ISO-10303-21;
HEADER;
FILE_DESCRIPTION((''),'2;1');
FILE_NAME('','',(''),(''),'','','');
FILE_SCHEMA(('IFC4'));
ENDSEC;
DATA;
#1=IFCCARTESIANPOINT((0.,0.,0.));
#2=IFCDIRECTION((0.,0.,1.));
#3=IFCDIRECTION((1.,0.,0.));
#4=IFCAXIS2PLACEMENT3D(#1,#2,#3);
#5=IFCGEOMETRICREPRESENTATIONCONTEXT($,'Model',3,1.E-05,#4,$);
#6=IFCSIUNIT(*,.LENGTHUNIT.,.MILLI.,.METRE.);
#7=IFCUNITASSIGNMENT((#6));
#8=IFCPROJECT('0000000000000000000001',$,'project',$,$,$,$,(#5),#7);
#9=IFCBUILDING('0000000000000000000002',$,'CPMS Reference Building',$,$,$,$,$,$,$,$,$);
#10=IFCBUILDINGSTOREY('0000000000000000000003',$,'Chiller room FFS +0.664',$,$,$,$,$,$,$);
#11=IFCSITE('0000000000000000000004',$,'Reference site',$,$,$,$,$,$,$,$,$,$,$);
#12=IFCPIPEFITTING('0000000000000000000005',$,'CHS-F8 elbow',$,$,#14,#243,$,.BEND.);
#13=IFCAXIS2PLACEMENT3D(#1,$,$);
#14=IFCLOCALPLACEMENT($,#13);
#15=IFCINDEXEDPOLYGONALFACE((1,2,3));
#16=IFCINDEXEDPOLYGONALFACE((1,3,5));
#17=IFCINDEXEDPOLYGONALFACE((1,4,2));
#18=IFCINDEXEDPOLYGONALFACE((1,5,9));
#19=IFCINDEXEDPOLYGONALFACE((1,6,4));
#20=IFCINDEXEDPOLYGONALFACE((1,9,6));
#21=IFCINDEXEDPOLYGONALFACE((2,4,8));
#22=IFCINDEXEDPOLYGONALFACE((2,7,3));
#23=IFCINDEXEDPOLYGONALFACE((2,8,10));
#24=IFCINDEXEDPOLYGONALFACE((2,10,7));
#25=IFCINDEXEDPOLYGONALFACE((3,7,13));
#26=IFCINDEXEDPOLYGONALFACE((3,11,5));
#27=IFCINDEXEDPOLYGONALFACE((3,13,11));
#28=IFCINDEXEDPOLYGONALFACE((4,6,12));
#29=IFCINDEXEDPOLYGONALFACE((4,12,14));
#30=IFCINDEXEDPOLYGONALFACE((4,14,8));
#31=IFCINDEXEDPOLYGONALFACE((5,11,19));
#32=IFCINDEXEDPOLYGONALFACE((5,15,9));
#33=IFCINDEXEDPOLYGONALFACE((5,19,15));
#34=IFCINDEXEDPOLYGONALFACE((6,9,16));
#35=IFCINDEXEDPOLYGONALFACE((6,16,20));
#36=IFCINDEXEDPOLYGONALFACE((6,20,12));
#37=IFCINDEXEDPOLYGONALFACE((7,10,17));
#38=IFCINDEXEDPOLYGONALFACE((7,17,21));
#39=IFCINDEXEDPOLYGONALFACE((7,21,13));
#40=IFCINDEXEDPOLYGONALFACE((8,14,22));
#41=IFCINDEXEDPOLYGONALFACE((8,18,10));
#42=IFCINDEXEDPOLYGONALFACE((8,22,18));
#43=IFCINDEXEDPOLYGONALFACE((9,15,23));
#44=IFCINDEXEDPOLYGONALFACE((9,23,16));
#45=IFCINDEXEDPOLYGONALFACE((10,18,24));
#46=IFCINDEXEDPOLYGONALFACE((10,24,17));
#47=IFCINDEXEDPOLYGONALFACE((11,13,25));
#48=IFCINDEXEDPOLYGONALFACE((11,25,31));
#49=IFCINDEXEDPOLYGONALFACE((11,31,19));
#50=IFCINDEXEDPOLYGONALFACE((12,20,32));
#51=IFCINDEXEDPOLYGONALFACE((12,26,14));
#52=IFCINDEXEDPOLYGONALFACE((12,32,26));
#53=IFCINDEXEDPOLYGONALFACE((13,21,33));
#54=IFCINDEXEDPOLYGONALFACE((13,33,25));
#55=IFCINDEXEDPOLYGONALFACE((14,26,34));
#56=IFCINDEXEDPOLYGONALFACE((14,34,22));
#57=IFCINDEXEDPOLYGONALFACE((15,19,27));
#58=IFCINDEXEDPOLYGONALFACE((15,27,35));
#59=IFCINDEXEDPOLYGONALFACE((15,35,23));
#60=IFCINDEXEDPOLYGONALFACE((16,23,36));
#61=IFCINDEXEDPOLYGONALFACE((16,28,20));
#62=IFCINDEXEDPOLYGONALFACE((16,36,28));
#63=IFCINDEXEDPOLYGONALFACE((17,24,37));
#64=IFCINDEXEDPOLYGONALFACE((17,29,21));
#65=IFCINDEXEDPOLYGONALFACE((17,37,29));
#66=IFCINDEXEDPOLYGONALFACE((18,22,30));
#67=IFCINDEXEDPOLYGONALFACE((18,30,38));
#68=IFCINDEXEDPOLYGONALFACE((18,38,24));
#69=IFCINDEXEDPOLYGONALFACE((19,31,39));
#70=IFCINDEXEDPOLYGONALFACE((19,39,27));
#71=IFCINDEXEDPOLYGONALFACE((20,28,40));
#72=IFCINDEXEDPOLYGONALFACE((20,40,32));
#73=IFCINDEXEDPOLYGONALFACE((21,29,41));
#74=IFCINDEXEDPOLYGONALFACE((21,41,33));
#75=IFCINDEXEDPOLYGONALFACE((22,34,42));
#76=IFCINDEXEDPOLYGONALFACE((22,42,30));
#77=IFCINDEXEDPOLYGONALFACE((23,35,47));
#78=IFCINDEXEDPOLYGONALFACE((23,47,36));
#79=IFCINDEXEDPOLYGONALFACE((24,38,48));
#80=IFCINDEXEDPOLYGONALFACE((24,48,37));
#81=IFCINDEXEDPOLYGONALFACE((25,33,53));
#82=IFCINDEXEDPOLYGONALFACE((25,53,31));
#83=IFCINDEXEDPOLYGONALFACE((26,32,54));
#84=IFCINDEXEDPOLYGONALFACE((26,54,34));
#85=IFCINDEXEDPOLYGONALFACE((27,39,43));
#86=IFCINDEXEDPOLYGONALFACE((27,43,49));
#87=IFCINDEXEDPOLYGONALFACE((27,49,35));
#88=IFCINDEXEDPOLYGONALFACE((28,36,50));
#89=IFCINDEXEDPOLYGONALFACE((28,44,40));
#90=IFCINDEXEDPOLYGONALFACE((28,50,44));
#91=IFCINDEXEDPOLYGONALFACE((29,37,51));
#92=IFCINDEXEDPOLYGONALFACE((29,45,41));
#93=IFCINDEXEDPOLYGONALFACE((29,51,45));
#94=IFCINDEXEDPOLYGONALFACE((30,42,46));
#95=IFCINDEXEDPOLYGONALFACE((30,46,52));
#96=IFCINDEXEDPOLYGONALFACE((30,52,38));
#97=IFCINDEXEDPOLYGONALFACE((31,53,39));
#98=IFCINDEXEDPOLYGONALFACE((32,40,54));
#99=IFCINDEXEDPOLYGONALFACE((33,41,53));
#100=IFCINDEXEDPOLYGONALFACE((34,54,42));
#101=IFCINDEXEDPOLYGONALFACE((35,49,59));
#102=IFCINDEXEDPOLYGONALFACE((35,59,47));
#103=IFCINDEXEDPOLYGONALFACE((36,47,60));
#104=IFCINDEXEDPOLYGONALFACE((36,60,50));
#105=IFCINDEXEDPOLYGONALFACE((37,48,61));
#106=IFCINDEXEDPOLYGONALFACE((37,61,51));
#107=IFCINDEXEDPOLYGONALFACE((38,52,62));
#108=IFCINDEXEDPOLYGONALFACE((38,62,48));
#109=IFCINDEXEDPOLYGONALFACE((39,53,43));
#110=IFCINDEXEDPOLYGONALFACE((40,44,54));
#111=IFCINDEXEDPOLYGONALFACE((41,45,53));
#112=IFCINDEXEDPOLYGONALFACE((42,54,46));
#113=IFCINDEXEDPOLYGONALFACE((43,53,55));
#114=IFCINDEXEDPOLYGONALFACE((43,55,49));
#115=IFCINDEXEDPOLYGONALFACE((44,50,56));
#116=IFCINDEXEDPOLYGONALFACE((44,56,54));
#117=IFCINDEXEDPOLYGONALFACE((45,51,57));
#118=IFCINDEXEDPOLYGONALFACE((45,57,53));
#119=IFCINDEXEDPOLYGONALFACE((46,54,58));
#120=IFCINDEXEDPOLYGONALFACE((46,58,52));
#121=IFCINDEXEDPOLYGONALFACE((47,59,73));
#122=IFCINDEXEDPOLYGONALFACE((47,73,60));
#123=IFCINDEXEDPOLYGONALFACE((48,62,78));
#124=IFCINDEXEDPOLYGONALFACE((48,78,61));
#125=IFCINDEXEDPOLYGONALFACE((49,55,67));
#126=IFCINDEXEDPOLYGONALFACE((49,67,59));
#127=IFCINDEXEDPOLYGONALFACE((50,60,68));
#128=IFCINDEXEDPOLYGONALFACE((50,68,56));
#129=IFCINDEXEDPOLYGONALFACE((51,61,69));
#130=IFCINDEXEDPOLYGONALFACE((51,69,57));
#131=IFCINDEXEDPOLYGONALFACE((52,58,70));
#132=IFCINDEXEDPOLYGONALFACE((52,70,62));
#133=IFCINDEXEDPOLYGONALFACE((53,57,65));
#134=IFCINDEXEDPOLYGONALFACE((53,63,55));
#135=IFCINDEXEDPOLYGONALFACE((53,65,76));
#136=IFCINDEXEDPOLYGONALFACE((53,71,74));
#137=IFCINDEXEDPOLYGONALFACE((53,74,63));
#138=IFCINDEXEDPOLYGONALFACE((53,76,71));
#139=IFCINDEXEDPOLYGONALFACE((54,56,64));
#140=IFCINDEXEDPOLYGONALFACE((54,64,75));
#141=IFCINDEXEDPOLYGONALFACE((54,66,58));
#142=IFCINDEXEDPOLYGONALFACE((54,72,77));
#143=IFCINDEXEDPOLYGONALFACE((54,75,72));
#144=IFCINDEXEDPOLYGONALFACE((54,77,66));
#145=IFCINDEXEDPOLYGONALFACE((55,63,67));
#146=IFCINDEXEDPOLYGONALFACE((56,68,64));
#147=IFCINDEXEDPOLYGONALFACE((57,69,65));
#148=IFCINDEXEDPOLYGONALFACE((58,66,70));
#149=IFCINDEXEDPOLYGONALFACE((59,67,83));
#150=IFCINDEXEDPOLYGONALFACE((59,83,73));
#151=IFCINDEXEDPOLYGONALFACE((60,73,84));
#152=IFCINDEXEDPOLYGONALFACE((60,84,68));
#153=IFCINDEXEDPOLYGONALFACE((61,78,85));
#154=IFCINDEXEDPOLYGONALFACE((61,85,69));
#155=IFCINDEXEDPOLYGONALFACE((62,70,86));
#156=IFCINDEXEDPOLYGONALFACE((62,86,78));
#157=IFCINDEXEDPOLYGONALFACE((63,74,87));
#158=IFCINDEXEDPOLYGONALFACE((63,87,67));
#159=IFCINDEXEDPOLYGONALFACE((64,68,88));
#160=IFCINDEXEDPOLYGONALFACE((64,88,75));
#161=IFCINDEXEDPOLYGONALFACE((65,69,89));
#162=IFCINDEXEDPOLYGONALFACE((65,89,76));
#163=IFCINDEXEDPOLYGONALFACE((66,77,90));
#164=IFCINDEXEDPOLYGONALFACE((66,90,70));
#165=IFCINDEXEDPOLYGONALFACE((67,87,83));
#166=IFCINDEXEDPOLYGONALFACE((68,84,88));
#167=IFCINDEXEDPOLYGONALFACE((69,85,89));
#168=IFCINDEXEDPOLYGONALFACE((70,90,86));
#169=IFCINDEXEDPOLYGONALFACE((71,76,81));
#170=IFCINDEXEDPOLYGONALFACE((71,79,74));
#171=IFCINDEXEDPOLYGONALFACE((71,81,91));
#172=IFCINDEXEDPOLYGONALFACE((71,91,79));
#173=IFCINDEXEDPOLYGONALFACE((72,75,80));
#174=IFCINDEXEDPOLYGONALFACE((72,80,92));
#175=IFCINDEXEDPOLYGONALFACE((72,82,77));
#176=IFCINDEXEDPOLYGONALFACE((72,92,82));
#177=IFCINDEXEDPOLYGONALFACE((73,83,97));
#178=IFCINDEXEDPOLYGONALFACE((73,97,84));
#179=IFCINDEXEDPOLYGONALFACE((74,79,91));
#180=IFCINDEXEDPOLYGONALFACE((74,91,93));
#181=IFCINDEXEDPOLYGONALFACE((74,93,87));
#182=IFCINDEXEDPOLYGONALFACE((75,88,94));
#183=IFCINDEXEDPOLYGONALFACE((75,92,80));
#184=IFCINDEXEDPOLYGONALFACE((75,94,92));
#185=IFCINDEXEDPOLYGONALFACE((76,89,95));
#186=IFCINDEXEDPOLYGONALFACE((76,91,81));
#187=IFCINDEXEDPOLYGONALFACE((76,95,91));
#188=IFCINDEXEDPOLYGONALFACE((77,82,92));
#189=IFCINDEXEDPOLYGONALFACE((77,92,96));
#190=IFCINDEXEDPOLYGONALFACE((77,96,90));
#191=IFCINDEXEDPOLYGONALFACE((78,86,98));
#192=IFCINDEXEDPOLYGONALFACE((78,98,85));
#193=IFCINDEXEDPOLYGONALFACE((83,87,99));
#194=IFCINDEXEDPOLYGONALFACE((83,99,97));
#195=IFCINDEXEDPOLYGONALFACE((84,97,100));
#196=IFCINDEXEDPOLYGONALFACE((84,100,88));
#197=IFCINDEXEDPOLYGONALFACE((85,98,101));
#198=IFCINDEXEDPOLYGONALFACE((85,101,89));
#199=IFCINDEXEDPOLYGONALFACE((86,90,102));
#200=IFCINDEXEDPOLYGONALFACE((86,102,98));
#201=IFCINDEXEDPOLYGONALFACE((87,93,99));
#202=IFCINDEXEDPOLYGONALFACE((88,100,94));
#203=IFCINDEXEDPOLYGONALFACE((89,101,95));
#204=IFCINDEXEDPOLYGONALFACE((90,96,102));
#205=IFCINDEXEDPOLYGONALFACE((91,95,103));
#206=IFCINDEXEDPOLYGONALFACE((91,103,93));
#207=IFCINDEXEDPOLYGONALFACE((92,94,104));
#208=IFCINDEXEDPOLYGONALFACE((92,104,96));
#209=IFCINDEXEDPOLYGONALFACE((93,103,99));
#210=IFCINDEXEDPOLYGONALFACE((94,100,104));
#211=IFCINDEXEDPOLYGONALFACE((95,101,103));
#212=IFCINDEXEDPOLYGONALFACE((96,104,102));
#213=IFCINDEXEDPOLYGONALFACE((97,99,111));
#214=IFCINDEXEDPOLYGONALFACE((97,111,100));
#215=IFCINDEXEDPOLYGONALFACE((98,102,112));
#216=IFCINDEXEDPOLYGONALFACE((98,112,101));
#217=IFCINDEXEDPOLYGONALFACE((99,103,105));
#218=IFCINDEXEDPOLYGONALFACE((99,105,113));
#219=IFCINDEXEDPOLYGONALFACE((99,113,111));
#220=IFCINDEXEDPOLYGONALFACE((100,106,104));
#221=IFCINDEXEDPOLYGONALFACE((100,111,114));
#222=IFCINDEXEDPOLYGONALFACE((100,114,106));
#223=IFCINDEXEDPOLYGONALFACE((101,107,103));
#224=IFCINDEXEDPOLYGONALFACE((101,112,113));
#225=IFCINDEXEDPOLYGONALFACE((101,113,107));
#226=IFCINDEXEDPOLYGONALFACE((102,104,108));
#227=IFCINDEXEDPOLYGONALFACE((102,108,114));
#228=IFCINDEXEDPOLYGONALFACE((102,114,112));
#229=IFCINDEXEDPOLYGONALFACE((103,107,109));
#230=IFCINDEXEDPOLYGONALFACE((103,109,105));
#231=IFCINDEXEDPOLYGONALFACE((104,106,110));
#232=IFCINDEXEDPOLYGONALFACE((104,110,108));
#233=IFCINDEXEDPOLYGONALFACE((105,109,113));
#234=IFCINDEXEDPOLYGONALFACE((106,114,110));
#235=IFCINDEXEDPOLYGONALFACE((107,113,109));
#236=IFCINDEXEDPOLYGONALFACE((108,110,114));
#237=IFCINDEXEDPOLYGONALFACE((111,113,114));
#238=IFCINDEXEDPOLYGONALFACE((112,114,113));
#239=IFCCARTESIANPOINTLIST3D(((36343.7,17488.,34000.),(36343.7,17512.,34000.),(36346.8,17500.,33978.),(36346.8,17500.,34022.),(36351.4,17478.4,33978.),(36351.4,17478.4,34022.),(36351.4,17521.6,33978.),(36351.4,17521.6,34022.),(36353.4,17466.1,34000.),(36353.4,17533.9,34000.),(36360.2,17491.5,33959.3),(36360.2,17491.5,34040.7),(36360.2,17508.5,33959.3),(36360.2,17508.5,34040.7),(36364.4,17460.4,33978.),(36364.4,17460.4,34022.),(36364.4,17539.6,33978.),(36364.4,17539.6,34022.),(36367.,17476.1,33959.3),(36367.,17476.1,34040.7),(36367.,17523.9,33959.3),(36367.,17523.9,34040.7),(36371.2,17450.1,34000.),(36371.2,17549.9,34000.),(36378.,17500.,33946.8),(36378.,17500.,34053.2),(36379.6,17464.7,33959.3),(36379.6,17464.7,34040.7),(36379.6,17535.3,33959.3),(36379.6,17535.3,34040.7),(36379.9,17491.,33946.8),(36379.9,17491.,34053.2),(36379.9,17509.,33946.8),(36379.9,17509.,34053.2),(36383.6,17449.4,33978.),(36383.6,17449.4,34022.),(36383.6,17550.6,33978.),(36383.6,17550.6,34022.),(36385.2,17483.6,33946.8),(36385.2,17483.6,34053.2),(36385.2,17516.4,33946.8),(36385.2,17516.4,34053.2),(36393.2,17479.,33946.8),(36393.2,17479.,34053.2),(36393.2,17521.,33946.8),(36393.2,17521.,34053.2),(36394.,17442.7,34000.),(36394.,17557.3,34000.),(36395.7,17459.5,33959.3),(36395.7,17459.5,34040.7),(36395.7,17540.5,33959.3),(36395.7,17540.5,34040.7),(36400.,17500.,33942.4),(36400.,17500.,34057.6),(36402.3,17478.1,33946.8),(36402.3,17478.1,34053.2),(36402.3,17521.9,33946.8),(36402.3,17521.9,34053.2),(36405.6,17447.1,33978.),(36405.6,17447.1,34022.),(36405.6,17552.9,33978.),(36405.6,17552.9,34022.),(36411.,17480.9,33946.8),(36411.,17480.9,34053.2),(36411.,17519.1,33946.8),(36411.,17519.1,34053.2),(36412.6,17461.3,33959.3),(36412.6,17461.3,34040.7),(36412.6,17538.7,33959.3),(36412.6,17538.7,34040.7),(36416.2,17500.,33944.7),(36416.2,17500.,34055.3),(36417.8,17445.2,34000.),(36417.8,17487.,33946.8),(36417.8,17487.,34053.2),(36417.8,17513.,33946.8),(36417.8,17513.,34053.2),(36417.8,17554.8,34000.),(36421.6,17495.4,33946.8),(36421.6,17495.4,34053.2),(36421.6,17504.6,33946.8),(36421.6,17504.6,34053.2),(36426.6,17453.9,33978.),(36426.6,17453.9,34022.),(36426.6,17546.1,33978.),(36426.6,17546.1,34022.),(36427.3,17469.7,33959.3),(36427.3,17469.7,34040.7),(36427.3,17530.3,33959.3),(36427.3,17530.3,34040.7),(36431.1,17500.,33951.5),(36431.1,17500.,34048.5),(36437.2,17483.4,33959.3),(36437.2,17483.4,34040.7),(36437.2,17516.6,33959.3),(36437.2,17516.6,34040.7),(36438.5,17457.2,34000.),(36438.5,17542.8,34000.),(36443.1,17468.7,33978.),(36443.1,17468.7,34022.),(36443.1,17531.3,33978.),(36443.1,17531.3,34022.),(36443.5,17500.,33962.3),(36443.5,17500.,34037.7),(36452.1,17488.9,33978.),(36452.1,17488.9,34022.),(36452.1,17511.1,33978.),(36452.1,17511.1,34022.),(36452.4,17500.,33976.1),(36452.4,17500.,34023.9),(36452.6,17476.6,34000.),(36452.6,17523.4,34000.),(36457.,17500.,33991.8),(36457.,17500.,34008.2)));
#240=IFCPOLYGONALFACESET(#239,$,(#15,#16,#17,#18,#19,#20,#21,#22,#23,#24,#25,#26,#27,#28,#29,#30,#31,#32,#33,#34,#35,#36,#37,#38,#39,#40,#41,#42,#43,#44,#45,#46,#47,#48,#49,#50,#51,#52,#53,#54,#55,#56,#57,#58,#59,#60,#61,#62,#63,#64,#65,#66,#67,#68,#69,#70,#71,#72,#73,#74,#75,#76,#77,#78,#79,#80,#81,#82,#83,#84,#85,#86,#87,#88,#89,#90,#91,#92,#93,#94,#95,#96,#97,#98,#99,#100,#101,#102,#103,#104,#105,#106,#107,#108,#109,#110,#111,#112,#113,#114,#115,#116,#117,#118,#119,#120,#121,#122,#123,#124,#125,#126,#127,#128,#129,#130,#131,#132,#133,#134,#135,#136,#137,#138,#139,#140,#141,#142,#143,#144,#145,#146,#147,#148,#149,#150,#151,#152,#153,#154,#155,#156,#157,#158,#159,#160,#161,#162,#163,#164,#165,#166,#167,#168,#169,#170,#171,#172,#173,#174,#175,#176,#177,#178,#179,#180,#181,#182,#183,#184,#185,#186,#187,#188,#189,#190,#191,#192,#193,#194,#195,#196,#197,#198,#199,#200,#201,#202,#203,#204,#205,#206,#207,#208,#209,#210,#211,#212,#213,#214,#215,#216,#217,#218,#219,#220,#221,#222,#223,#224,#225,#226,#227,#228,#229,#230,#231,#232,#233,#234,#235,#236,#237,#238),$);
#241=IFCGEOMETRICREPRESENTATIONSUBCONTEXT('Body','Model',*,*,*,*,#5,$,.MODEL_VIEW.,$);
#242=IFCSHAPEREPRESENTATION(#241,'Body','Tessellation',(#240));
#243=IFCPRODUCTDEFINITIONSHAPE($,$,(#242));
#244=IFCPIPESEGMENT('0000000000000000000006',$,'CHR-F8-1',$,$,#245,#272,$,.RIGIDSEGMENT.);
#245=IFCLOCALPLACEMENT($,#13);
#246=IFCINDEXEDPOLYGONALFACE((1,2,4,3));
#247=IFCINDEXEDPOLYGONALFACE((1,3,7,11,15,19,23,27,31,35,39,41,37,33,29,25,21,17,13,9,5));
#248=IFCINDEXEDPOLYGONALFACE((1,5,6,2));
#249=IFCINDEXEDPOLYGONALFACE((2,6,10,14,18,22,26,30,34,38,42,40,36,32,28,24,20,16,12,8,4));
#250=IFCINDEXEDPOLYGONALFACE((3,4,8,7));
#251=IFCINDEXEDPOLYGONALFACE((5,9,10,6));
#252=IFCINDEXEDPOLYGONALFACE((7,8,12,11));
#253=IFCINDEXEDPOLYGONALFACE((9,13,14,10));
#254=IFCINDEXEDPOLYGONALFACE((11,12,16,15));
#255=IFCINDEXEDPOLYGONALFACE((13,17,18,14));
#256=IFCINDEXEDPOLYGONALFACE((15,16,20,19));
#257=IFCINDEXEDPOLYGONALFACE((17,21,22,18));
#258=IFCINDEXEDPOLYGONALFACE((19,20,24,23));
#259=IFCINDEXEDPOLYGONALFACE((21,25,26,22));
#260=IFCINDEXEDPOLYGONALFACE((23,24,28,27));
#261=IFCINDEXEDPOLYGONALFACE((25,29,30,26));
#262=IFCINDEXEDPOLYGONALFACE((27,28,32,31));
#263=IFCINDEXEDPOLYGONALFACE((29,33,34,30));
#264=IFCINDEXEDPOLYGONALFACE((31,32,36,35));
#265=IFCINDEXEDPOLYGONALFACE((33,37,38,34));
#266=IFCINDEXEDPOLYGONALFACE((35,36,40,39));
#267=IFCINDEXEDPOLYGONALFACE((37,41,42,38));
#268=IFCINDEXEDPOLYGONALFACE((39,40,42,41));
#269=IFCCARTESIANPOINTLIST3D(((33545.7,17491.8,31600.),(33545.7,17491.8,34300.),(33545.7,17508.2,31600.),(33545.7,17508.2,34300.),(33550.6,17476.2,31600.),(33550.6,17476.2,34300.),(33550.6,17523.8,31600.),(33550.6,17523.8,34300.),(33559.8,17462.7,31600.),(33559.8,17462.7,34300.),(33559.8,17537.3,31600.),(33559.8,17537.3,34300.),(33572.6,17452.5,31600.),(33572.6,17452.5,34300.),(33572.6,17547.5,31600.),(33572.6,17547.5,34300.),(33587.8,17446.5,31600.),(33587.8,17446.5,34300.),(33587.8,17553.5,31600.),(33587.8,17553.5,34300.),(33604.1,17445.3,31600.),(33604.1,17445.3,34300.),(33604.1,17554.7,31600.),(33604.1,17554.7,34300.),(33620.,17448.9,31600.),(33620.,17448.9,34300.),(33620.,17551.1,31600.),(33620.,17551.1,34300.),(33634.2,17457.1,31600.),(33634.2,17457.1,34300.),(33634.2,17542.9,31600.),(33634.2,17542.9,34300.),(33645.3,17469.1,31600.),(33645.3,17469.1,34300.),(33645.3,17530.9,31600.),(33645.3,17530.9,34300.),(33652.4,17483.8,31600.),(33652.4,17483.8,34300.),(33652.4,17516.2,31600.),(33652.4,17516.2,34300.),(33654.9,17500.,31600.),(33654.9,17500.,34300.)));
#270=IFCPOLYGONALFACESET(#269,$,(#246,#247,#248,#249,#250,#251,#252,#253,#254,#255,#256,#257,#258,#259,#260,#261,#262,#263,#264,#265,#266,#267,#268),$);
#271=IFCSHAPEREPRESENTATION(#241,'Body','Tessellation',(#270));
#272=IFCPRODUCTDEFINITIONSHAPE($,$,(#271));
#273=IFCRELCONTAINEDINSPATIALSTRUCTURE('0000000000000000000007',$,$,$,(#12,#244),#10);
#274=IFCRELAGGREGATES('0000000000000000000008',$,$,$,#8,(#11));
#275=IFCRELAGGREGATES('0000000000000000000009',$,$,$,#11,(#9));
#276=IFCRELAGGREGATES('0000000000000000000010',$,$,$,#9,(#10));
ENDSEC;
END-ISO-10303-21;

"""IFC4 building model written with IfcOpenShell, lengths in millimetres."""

from ifc_helpers import new_model, entity, si_unit, frame, origin_with_axes, origin_2d, place, context, subcontext, project, spatial, circle_curve, outline, extrude, element, save


model = new_model("IFC4")

# Units and contexts
model_context = context("Model", 3, precision=1e-05, world=origin_with_axes())
body_context = subcontext(model_context, "Body", "Model", "MODEL_VIEW")
ifc_project = project(units=[si_unit("LENGTHUNIT", "METRE", prefix="MILLI")], contexts=[model_context])

# Site, building, storey
site = spatial("IfcSite", under=ifc_project, Name="Reference site")
building = spatial("IfcBuilding", under=site, Name="CPMS Reference Building")
storey = spatial("IfcBuildingStorey", under=building, Name="Chiller room FFS +0.664")

# Pipe fitting
pipe_fitting_1_placement = place(None, origin_with_axes())
element("IfcPipeFitting", 1, at=pipe_fitting_1_placement, inside=storey, Name="CHS-F8 elbow", PredefinedType="BEND", context=body_context, shape_type="CSG", body=[
    entity("IfcSphere", entity("IfcAxis2Placement3D", entity("IfcCartesianPoint", [36400.0, 17500.0, 34000.0]), entity("IfcDirection", [0.0, 0.0, 1.0]), entity("IfcDirection", [1.0, 0.0, 0.0])), 57.6),
])

# Pipe segment
pipe_segment_1_placement = place(None, origin_with_axes())
element("IfcPipeSegment", 2, at=pipe_segment_1_placement, inside=storey, Name="CHR-F8-1", PredefinedType="RIGIDSEGMENT", context=body_context, shape_type="SweptSolid", body=[
    extrude(outline(circle_curve(origin_2d(), 54.9)), frame((33600.0, 17500.0, 31600.0), z_axis=(0.0, 0.0, 1.0), x_axis=(1.0, 0.0, 0.0)), (0.0, 0.0, 1.0), 2700.0),
])

save(model, "model.ifc")
